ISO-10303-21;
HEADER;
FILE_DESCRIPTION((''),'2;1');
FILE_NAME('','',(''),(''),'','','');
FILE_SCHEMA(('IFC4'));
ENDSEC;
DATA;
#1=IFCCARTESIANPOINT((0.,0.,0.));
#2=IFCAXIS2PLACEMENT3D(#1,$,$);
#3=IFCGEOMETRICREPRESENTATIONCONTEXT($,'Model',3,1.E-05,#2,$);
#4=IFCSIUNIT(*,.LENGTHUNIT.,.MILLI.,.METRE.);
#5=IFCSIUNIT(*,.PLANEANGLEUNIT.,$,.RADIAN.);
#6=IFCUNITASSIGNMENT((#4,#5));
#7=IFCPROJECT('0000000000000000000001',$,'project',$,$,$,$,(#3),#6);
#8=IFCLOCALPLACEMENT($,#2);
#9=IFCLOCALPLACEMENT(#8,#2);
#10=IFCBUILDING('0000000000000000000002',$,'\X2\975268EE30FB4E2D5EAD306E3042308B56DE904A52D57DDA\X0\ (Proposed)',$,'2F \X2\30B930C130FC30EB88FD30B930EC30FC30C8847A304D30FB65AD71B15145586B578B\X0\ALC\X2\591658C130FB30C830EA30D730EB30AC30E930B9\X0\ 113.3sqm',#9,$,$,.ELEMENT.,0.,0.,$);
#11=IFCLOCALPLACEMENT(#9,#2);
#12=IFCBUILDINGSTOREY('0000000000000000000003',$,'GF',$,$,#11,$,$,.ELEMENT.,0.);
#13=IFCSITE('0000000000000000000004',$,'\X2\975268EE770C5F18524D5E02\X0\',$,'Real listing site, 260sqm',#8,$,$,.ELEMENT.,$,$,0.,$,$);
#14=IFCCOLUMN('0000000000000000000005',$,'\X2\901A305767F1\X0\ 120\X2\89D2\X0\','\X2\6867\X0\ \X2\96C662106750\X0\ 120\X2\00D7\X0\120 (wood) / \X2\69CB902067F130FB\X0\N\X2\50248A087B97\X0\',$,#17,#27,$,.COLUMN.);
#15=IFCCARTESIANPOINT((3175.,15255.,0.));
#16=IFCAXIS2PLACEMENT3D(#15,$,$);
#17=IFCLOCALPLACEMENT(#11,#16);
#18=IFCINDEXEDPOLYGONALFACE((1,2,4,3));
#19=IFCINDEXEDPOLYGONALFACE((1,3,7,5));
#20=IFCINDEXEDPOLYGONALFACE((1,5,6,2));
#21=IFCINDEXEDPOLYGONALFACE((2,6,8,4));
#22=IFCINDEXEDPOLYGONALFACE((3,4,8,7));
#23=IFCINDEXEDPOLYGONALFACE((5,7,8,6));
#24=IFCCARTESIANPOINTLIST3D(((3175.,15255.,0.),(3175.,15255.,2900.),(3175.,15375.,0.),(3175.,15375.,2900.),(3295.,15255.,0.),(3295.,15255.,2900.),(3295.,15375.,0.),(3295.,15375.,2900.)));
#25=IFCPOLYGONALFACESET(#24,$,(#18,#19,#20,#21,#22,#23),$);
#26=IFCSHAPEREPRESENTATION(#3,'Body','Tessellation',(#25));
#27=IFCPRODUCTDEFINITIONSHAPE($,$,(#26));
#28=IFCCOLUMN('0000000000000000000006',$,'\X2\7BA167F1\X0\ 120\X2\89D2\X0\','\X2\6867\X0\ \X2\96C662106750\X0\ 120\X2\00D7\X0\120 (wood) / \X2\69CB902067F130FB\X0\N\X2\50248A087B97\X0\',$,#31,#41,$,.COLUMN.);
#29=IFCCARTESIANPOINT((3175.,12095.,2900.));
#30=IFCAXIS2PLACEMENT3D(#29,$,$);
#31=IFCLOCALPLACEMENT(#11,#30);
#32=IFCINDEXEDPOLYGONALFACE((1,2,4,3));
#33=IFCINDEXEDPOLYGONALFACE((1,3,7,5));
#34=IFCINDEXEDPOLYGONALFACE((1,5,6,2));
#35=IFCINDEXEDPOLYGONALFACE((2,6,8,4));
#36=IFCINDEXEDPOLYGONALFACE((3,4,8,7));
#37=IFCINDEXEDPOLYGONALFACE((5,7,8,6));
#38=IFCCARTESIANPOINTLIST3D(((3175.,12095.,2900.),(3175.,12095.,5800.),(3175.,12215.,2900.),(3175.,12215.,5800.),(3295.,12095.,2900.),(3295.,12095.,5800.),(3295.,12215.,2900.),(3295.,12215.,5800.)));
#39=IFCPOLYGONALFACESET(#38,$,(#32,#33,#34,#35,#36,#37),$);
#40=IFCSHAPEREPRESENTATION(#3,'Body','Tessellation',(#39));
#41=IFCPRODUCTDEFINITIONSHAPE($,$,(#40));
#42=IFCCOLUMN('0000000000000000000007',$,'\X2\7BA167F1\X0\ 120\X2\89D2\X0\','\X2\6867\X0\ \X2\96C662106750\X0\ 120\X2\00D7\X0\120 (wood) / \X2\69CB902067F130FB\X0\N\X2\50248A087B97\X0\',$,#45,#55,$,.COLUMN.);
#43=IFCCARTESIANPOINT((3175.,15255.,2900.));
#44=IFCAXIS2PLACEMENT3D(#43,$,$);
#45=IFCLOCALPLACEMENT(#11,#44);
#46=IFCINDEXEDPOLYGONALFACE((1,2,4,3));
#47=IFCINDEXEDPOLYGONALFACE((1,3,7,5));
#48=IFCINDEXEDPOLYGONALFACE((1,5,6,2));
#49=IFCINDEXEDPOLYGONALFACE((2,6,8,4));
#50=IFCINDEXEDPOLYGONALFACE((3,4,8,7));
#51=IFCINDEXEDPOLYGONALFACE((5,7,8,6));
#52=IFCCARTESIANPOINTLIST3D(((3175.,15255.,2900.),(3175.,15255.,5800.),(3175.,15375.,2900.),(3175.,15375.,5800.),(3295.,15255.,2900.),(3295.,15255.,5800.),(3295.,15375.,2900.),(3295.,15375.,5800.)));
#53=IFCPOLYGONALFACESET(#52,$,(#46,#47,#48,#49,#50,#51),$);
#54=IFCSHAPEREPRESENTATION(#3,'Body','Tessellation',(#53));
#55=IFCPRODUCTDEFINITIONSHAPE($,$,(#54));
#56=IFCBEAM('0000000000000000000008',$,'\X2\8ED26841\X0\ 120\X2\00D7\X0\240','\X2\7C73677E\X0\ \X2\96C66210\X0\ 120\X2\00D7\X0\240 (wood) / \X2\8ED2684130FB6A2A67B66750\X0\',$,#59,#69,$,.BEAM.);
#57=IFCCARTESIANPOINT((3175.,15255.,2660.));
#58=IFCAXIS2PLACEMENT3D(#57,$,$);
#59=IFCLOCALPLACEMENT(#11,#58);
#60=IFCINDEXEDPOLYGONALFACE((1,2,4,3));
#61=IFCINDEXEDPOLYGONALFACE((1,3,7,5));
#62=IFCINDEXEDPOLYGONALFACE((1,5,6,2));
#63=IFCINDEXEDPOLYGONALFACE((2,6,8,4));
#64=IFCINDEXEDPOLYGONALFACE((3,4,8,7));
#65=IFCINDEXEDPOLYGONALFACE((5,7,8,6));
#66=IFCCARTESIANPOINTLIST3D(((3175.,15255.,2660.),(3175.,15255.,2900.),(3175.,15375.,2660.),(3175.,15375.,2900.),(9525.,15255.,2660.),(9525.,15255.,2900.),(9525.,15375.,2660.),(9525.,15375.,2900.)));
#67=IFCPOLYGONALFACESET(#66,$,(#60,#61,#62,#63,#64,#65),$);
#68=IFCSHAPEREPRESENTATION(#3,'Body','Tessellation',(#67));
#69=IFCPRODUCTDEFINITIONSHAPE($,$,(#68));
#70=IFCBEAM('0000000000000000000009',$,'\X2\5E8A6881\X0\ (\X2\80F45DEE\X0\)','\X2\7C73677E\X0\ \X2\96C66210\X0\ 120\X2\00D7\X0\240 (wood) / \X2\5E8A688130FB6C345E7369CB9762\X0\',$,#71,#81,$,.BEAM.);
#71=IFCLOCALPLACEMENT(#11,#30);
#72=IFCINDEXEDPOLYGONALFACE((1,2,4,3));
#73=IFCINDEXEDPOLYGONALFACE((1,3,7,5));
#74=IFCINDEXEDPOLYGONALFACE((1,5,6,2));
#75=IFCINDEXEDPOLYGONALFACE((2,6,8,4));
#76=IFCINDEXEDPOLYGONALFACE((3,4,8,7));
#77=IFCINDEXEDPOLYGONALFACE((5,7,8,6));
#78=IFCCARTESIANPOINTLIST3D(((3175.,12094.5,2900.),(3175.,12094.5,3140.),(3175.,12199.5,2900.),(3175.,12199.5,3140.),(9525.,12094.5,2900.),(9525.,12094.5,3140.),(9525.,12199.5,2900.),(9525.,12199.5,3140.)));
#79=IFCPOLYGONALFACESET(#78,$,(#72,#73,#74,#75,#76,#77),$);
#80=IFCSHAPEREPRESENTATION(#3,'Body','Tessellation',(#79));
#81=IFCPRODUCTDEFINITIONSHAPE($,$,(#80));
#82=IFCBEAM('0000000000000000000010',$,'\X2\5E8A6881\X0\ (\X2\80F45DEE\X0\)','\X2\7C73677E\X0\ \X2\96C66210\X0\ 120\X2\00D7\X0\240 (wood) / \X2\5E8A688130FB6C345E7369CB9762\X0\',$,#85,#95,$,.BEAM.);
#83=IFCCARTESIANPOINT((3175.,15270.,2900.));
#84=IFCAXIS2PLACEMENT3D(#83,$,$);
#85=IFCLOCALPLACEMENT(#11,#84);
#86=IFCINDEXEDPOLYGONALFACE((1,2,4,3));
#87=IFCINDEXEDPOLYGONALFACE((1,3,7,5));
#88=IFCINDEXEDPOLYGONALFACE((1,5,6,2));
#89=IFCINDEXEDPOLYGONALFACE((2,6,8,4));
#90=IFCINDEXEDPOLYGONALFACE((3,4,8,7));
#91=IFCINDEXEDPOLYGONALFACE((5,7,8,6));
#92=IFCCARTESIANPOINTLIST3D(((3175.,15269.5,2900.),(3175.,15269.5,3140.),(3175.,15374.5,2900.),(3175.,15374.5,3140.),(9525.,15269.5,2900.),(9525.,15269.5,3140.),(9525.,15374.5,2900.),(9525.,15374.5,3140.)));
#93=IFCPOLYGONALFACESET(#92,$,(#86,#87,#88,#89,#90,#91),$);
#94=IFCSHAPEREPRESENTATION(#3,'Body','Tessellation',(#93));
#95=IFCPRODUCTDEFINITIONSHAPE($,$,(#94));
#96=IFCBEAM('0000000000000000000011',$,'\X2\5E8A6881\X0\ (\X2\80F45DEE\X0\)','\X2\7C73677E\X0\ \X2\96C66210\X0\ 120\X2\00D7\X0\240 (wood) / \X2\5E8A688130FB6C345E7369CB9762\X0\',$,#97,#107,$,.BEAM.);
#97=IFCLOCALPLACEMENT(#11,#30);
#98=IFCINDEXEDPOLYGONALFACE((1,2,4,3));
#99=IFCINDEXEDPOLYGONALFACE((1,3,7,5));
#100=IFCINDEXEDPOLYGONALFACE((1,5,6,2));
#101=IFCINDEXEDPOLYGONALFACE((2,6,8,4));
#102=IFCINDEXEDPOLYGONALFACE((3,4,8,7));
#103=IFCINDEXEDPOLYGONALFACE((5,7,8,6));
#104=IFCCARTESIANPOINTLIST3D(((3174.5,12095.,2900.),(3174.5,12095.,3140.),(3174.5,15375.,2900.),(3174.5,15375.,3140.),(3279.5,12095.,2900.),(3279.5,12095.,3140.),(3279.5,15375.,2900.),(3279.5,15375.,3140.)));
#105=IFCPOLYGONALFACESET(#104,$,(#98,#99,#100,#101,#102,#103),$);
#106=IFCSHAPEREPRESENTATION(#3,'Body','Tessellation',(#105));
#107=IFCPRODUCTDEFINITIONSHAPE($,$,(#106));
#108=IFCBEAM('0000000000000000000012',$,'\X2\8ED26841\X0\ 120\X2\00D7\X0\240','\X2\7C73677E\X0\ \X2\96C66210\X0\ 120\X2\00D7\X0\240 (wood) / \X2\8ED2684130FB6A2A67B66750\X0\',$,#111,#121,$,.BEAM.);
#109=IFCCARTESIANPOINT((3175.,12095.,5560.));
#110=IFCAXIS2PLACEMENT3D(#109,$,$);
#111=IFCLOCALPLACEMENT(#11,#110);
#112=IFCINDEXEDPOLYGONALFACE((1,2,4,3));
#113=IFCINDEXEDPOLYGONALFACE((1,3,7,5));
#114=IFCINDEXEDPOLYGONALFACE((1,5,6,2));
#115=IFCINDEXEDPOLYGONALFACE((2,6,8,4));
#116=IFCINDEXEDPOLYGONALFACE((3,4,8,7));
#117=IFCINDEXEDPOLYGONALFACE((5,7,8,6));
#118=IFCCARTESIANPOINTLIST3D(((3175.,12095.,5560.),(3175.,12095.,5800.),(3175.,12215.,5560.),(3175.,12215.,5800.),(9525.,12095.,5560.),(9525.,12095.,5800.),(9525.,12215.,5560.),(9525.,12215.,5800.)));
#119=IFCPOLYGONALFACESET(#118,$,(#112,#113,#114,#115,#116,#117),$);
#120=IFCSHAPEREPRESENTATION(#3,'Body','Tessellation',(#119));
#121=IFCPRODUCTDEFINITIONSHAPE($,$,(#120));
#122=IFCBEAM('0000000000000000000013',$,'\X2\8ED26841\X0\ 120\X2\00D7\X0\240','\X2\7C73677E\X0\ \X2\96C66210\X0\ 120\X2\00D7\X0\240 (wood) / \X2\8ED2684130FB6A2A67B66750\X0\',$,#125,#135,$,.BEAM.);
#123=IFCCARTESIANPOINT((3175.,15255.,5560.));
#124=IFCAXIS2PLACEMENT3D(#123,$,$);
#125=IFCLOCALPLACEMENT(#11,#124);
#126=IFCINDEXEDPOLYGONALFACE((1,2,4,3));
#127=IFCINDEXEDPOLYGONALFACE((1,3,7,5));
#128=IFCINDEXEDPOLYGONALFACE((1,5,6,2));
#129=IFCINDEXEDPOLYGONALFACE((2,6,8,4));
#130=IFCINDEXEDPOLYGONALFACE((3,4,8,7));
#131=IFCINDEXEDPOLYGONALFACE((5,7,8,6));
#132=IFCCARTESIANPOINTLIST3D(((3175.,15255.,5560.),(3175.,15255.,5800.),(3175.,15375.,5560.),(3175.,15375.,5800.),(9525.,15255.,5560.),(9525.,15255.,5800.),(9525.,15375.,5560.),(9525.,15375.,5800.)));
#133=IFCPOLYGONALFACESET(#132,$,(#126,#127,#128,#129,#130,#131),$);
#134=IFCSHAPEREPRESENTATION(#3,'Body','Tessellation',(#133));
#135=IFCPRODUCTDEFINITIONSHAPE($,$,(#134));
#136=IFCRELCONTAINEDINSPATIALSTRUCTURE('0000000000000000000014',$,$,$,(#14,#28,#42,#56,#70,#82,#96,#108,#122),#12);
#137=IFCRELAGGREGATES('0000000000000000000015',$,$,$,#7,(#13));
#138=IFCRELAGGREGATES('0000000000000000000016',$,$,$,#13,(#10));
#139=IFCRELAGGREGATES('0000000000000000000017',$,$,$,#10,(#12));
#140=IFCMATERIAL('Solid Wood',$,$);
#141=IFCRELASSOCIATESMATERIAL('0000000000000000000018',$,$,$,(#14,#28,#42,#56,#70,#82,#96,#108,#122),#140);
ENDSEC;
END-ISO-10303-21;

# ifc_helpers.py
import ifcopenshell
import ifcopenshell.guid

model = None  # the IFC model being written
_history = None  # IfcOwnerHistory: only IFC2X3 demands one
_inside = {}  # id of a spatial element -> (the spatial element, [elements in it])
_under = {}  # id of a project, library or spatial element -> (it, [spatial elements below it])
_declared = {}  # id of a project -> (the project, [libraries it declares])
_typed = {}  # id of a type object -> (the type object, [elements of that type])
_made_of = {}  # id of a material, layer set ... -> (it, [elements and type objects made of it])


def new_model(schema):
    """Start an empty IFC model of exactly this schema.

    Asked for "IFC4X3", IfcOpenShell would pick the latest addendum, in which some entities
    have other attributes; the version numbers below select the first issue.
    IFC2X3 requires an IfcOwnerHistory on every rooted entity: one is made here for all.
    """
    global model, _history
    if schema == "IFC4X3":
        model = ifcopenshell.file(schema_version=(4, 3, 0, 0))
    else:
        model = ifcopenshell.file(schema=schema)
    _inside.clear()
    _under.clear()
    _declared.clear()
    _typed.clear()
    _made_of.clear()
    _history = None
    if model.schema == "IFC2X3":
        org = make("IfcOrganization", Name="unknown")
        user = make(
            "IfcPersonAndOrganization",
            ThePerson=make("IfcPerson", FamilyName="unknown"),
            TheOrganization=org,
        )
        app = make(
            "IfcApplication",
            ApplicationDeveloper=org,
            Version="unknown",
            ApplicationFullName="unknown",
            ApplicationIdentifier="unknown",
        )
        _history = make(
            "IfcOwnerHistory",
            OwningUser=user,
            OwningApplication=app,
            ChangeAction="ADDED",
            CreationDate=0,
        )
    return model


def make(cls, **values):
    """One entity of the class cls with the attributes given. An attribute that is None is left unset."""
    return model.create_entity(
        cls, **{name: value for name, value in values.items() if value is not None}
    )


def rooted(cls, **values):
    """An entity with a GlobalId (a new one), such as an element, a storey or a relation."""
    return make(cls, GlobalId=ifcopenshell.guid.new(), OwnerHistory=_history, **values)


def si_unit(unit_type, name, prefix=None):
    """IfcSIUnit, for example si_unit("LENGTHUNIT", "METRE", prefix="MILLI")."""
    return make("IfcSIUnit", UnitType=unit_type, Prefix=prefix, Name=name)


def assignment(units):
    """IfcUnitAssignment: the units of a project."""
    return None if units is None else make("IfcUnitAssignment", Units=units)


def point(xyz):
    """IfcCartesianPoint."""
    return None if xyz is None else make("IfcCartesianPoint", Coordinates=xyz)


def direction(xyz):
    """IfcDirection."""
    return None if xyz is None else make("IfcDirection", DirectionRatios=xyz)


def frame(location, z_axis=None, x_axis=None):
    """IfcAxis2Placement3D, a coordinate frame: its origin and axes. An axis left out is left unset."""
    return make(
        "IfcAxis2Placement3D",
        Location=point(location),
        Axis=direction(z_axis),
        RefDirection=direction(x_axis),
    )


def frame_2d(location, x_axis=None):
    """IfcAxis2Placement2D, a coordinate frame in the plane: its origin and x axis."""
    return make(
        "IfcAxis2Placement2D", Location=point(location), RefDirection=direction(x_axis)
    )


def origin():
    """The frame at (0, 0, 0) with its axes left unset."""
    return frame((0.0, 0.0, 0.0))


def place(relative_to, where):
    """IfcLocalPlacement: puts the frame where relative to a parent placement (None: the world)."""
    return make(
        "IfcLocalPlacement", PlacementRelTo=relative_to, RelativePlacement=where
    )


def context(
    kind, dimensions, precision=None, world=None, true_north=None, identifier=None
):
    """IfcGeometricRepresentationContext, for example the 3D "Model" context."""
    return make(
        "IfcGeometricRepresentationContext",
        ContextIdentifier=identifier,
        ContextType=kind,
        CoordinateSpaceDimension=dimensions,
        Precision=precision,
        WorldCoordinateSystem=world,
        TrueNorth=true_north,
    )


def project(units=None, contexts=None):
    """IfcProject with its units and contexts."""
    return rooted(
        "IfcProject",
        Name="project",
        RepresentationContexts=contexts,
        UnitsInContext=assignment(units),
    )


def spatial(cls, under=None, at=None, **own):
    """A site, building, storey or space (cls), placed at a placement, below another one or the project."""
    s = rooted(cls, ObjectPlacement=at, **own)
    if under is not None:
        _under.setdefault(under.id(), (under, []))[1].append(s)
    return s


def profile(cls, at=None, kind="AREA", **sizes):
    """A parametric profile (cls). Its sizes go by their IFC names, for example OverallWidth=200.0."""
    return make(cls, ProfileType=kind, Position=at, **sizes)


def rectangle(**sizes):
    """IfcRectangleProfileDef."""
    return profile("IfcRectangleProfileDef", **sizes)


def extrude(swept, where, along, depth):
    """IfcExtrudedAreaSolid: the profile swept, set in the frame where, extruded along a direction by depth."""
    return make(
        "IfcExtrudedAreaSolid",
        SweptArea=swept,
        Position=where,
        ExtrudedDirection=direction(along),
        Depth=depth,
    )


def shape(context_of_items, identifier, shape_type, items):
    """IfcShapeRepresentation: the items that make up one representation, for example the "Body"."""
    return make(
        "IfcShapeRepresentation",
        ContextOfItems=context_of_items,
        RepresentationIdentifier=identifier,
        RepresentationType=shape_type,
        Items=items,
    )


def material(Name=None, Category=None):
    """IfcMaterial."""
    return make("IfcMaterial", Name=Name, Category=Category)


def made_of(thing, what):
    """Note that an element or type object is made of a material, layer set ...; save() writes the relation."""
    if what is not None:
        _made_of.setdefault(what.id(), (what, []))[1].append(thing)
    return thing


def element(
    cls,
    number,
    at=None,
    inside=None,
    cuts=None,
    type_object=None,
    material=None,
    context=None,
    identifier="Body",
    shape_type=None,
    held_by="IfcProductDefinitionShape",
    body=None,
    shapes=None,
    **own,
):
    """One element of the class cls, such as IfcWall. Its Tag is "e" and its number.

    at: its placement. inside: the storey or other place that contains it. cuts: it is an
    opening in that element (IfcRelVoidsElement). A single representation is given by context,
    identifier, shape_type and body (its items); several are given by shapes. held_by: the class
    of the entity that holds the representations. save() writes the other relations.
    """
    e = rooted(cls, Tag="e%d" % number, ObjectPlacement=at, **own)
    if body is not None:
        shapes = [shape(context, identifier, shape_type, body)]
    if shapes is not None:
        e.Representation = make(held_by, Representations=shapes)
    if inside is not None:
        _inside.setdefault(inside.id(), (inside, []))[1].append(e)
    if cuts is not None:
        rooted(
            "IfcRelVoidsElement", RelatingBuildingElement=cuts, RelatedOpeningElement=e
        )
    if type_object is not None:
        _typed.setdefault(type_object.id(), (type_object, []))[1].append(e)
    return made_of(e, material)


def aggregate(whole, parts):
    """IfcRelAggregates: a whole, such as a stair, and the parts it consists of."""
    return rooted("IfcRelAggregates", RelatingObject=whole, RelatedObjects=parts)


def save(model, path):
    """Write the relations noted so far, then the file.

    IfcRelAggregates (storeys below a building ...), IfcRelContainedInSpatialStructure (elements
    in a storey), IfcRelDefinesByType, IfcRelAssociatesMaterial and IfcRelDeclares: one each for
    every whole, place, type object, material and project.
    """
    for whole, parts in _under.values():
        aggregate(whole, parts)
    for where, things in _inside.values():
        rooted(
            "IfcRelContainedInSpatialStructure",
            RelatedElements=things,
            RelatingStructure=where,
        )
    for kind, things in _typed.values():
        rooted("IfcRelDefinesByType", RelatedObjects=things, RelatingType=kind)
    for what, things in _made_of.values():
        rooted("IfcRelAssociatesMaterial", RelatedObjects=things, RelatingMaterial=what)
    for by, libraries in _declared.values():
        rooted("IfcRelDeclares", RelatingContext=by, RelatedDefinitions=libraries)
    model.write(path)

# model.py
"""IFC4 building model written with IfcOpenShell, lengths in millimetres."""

from ifc_helpers import new_model, si_unit, frame, frame_2d, origin, place, context, project, spatial, rectangle, extrude, material, element, save


model = new_model("IFC4")

# Units and contexts
model_context = context("Model", 3, precision=1e-05, world=origin())
ifc_project = project(units=[si_unit("LENGTHUNIT", "METRE", prefix="MILLI"), si_unit("PLANEANGLEUNIT", "RADIAN")], contexts=[model_context])

# Site, building, storey
site_placement = place(None, origin())
site = spatial("IfcSite", under=ifc_project, at=site_placement, Name="青森県弘前市", ObjectType="Real listing site, 260sqm", CompositionType="ELEMENT", RefElevation=0.0)
building_placement = place(site_placement, origin())
building = spatial("IfcBuilding", under=site, at=building_placement, Name="青森・中庭のある回遊動線 (Proposed)", ObjectType="2F スチール製スレート葺き・断熱充填型ALC外壁・トリプルガラス 113.3sqm", CompositionType="ELEMENT", ElevationOfRefHeight=0.0, ElevationOfTerrain=0.0)
storey_placement = place(building_placement, origin())
storey = spatial("IfcBuildingStorey", under=building, at=storey_placement, Name="GF", CompositionType="ELEMENT", Elevation=0.0)

# Columns
ifc_material_1 = material(Name="Solid Wood")
column_1_placement = place(storey_placement, frame((3175.0, 15255.0, 0.0)))
element("IfcColumn", 1, at=column_1_placement, inside=storey, material=ifc_material_1, Name="通し柱 120角", Description="桧 集成材 120×120 (wood) / 構造柱・N値計算", PredefinedType="COLUMN", context=model_context, shape_type="SweptSolid", body=[
    extrude(rectangle(XDim=120.0, YDim=120.0, at=frame_2d((60.0, 60.0))), frame((3175.0, 15255.0, 0.0)), (0.0, 0.0, 1.0), 2900.0),
])
column_2_placement = place(storey_placement, frame((3175.0, 12095.0, 2900.0)))
element("IfcColumn", 2, at=column_2_placement, inside=storey, material=ifc_material_1, Name="管柱 120角", Description="桧 集成材 120×120 (wood) / 構造柱・N値計算", PredefinedType="COLUMN", context=model_context, shape_type="SweptSolid", body=[
    extrude(rectangle(XDim=120.0, YDim=120.0, at=frame_2d((60.0, 60.0))), frame((3175.0, 12095.0, 2900.0)), (0.0, 0.0, 1.0), 2900.0),
])
column_3_placement = place(storey_placement, frame((3175.0, 15255.0, 2900.0)))
element("IfcColumn", 3, at=column_3_placement, inside=storey, material=ifc_material_1, Name="管柱 120角", Description="桧 集成材 120×120 (wood) / 構造柱・N値計算", PredefinedType="COLUMN", context=model_context, shape_type="SweptSolid", body=[
    extrude(rectangle(XDim=120.0, YDim=120.0, at=frame_2d((60.0, 60.0))), frame((3175.0, 15255.0, 2900.0)), (0.0, 0.0, 1.0), 2900.0),
])

# Beams
beam_1_placement = place(storey_placement, frame((3175.0, 15255.0, 2660.0)))
element("IfcBeam", 4, at=beam_1_placement, inside=storey, material=ifc_material_1, Name="軒桁 120×240", Description="米松 集成 120×240 (wood) / 軒桁・横架材", PredefinedType="BEAM", context=model_context, shape_type="SweptSolid", body=[
    extrude(rectangle(XDim=6350.0, YDim=120.0, at=frame_2d((3175.0, 60.0))), frame((3175.0, 15255.0, 2660.0)), (0.0, 0.0, 1.0), 240.0),
])
beam_2_placement = place(storey_placement, frame((3175.0, 12095.0, 2900.0)))
element("IfcBeam", 5, at=beam_2_placement, inside=storey, material=ifc_material_1, Name="床梁 (胴差)", Description="米松 集成 120×240 (wood) / 床梁・水平構面", PredefinedType="BEAM", context=model_context, shape_type="SweptSolid", body=[
    extrude(rectangle(XDim=6350.0, YDim=105.0, at=frame_2d((3175.0, 52.0))), frame((3175.0, 12095.0, 2900.0)), (0.0, 0.0, 1.0), 240.0),
])
beam_3_placement = place(storey_placement, frame((3175.0, 15270.0, 2900.0)))
element("IfcBeam", 6, at=beam_3_placement, inside=storey, material=ifc_material_1, Name="床梁 (胴差)", Description="米松 集成 120×240 (wood) / 床梁・水平構面", PredefinedType="BEAM", context=model_context, shape_type="SweptSolid", body=[
    extrude(rectangle(XDim=6350.0, YDim=105.0, at=frame_2d((3175.0, 52.0))), frame((3175.0, 15270.0, 2900.0)), (0.0, 0.0, 1.0), 240.0),
])
beam_4_placement = place(storey_placement, frame((3175.0, 12095.0, 2900.0)))
element("IfcBeam", 7, at=beam_4_placement, inside=storey, material=ifc_material_1, Name="床梁 (胴差)", Description="米松 集成 120×240 (wood) / 床梁・水平構面", PredefinedType="BEAM", context=model_context, shape_type="SweptSolid", body=[
    extrude(rectangle(XDim=105.0, YDim=3280.0, at=frame_2d((52.0, 1640.0))), frame((3175.0, 12095.0, 2900.0)), (0.0, 0.0, 1.0), 240.0),
])
beam_5_placement = place(storey_placement, frame((3175.0, 12095.0, 5560.0)))
element("IfcBeam", 8, at=beam_5_placement, inside=storey, material=ifc_material_1, Name="軒桁 120×240", Description="米松 集成 120×240 (wood) / 軒桁・横架材", PredefinedType="BEAM", context=model_context, shape_type="SweptSolid", body=[
    extrude(rectangle(XDim=6350.0, YDim=120.0, at=frame_2d((3175.0, 60.0))), frame((3175.0, 12095.0, 5560.0)), (0.0, 0.0, 1.0), 240.0),
])
beam_6_placement = place(storey_placement, frame((3175.0, 15255.0, 5560.0)))
element("IfcBeam", 9, at=beam_6_placement, inside=storey, material=ifc_material_1, Name="軒桁 120×240", Description="米松 集成 120×240 (wood) / 軒桁・横架材", PredefinedType="BEAM", context=model_context, shape_type="SweptSolid", body=[
    extrude(rectangle(XDim=6350.0, YDim=120.0, at=frame_2d((3175.0, 60.0))), frame((3175.0, 15255.0, 5560.0)), (0.0, 0.0, 1.0), 240.0),
])

save(model, "model.ifc")
